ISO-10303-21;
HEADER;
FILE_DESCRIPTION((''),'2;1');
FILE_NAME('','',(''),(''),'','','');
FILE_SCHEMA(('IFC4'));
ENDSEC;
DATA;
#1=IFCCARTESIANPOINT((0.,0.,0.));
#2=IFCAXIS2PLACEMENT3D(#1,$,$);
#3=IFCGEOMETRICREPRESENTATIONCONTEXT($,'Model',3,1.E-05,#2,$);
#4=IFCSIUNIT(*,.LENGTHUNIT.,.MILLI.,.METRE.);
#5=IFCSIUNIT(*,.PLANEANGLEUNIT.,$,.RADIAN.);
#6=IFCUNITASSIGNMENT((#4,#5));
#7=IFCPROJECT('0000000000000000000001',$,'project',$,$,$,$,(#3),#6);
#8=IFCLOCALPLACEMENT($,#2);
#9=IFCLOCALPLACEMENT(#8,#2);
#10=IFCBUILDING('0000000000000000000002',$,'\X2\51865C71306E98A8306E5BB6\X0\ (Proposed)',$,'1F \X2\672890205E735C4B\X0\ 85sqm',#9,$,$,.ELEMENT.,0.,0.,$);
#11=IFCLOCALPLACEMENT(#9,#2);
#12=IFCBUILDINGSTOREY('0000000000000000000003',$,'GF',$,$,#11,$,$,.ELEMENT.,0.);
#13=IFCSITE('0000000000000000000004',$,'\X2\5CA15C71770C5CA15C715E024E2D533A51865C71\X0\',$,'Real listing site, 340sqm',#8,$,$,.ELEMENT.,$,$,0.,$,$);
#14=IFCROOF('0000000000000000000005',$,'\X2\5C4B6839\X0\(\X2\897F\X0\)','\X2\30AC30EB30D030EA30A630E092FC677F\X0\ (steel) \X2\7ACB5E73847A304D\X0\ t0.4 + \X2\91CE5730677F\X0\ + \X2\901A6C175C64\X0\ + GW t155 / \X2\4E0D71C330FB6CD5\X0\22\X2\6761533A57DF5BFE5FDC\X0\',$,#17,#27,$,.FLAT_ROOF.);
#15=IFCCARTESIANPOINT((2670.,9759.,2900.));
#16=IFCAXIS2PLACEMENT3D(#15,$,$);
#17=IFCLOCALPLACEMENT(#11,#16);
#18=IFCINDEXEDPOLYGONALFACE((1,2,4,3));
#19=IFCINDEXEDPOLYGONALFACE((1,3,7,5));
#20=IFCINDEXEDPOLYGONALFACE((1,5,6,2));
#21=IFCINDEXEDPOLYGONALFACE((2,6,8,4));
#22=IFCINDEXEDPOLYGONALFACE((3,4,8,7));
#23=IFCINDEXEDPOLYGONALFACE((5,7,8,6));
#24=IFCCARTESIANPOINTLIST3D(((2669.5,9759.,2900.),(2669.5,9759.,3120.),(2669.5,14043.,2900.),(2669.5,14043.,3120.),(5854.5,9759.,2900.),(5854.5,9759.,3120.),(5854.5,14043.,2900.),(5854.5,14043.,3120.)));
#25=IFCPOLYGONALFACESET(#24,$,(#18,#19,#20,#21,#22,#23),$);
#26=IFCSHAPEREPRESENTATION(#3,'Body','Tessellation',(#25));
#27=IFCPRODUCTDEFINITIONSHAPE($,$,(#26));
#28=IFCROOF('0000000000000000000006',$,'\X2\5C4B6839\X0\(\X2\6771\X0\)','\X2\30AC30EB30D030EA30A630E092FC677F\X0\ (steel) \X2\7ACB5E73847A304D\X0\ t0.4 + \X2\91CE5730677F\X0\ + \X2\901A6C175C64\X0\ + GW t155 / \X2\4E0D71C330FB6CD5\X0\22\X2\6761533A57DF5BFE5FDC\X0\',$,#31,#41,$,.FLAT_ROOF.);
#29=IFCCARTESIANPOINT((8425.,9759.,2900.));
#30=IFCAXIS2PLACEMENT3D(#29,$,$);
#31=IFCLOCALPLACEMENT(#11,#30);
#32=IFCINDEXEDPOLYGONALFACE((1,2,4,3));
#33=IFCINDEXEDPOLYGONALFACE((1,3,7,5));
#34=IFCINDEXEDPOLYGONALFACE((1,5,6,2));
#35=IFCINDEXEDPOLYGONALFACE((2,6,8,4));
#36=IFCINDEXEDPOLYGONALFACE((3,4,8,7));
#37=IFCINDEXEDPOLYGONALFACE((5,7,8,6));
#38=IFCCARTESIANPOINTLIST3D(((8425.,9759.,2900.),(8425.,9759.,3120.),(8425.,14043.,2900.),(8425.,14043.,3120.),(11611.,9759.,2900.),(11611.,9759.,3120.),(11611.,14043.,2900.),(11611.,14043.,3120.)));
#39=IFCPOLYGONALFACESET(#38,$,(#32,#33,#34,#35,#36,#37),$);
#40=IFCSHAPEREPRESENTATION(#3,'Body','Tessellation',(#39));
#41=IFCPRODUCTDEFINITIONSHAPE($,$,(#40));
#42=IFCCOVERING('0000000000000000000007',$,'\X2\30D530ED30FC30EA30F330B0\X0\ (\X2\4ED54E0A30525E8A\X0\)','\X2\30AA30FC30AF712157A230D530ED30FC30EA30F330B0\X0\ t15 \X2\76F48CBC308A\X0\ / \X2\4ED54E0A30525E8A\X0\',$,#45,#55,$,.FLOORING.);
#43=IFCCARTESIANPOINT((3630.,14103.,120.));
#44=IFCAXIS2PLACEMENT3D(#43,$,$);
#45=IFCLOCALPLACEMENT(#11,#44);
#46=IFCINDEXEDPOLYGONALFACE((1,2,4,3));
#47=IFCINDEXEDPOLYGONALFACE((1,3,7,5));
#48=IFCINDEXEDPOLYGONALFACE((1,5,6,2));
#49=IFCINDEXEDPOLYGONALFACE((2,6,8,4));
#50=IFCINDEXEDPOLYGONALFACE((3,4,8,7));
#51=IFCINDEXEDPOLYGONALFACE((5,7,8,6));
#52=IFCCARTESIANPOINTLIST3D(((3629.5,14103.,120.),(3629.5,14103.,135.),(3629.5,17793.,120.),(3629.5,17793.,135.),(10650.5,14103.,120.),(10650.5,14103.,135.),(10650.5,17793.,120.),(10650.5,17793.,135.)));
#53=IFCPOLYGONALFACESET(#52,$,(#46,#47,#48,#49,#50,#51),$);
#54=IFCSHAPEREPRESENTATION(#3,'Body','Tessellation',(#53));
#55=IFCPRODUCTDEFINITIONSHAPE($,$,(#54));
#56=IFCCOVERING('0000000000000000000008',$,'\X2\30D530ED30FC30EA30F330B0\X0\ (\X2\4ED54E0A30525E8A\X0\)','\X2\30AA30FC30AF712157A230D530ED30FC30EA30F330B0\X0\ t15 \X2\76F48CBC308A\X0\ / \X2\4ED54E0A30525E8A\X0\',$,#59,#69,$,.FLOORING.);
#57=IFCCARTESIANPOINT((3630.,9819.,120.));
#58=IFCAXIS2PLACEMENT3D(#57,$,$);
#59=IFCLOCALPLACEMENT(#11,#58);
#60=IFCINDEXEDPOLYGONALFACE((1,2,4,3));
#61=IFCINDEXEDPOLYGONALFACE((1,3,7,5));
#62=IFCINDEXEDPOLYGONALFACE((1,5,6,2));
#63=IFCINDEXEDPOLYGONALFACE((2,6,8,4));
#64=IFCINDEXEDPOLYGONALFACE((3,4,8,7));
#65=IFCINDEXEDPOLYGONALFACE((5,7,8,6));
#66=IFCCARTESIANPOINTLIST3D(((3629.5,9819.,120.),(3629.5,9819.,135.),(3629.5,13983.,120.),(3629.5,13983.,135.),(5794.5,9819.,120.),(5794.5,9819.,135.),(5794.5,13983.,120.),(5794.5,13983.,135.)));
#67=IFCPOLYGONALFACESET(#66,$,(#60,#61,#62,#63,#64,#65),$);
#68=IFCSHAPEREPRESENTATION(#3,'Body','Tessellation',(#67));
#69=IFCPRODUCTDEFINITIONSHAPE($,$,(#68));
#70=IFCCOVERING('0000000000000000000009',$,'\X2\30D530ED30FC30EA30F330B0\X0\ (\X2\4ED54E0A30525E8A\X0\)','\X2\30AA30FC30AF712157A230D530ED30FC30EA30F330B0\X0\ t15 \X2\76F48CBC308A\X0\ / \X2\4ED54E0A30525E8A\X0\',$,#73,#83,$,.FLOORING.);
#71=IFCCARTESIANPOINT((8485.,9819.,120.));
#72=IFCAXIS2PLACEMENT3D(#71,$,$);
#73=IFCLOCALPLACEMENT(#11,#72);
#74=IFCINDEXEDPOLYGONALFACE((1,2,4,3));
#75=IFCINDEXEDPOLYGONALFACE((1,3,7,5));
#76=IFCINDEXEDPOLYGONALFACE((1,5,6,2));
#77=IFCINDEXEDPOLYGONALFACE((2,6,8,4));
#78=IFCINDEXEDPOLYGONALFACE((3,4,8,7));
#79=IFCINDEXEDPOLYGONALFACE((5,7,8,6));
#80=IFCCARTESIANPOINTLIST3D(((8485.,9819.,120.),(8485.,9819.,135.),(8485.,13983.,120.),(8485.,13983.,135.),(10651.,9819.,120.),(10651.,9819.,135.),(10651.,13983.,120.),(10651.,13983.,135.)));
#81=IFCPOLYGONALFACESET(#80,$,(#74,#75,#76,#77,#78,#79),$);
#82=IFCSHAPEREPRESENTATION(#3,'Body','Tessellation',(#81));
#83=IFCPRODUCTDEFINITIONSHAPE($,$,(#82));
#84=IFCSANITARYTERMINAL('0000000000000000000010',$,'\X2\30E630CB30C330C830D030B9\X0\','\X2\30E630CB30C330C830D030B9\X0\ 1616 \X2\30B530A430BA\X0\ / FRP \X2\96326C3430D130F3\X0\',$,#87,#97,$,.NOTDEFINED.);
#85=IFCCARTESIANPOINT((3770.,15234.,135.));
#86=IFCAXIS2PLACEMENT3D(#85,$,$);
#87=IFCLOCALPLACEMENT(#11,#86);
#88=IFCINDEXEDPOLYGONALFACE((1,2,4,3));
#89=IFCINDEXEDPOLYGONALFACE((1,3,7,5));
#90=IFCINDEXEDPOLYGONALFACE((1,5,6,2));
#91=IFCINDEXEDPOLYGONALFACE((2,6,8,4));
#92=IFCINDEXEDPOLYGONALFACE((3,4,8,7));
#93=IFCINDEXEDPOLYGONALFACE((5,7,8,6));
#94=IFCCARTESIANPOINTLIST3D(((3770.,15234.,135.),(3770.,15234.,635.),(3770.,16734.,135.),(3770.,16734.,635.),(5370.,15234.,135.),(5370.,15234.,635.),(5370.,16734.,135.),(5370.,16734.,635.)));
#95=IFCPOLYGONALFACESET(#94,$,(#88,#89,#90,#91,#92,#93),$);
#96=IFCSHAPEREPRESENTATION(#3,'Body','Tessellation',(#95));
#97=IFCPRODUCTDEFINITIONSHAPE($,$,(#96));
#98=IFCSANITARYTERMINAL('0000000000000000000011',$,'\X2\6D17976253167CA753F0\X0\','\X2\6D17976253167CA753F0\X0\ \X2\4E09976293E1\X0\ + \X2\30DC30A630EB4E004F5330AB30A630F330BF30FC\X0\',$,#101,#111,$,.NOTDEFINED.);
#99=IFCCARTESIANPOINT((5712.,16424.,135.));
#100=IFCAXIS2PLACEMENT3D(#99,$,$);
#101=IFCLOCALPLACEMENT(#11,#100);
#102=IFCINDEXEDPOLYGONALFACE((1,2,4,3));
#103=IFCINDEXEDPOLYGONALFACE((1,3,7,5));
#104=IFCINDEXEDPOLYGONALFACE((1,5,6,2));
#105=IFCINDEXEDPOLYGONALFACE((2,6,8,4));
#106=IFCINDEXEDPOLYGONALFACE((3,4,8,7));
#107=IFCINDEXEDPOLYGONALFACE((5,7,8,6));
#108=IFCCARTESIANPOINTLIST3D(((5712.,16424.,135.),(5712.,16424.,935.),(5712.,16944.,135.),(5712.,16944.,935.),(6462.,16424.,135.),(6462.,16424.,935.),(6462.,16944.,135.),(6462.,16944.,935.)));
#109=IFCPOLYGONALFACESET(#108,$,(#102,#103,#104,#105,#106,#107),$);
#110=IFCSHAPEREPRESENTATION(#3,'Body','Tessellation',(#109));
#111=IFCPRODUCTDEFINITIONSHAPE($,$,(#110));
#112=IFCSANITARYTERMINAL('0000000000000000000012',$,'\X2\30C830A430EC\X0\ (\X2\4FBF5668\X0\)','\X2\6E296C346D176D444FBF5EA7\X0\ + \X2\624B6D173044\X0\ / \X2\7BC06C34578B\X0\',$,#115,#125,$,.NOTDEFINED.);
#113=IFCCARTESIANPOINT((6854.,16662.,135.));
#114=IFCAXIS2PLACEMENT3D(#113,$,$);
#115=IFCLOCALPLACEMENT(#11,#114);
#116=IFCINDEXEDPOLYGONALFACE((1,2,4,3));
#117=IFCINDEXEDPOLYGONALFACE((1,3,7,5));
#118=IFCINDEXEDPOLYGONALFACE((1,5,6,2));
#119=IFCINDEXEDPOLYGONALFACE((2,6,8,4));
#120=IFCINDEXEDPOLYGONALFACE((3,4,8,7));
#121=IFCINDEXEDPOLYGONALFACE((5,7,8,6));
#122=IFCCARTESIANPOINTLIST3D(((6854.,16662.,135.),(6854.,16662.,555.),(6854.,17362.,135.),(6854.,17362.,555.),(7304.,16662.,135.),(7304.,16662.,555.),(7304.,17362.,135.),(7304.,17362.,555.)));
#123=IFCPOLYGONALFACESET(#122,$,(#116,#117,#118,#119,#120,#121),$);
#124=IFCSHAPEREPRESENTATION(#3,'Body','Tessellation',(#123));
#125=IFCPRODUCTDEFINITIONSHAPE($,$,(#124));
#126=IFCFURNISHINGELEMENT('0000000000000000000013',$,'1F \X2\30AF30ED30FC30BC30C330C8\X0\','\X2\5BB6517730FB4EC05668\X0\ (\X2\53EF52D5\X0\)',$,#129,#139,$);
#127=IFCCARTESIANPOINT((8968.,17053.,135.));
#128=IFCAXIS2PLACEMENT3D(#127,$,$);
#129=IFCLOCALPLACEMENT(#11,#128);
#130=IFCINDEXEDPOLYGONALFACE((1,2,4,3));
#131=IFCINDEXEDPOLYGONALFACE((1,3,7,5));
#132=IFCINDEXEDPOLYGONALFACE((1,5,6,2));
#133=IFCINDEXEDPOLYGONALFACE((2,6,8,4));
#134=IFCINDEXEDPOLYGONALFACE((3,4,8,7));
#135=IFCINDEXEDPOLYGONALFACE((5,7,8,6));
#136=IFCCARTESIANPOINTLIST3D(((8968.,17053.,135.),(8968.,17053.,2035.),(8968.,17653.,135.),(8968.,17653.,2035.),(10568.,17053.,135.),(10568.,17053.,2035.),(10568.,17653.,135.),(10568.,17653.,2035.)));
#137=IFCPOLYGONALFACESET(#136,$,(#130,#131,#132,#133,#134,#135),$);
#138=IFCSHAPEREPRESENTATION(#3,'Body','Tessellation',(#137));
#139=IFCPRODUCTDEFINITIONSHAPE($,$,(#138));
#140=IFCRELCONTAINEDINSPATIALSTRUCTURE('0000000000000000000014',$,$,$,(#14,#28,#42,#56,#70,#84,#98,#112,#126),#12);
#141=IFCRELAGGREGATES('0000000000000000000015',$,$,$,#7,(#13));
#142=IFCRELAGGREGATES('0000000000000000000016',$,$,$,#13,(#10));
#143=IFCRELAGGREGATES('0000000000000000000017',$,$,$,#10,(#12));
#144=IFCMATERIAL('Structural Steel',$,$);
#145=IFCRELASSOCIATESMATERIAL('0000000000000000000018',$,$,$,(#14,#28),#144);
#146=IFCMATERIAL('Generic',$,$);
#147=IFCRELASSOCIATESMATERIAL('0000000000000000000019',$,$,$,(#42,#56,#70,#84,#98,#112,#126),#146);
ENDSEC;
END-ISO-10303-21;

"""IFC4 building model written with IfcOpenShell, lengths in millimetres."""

from ifc_helpers import new_model, si_unit, frame, frame_2d, origin, place, context, project, spatial, rectangle, extrude, material, element, save


model = new_model("IFC4")

# Units and contexts
model_context = context("Model", 3, precision=1e-05, world=origin())
ifc_project = project(units=[si_unit("LENGTHUNIT", "METRE", prefix="MILLI"), si_unit("PLANEANGLEUNIT", "RADIAN")], contexts=[model_context])

# Site, building, storey
site_placement = place(None, origin())
site = spatial("IfcSite", under=ifc_project, at=site_placement, Name="岡山県岡山市中区円山", ObjectType="Real listing site, 340sqm", CompositionType="ELEMENT", RefElevation=0.0)
building_placement = place(site_placement, origin())
building = spatial("IfcBuilding", under=site, at=building_placement, Name="円山の風の家 (Proposed)", ObjectType="1F 木造平屋 85sqm", CompositionType="ELEMENT", ElevationOfRefHeight=0.0, ElevationOfTerrain=0.0)
storey_placement = place(building_placement, origin())
storey = spatial("IfcBuildingStorey", under=building, at=storey_placement, Name="GF", CompositionType="ELEMENT", Elevation=0.0)

# Roofs
ifc_material_1 = material(Name="Structural Steel")
roof_1_placement = place(storey_placement, frame((2670.0, 9759.0, 2900.0)))
element("IfcRoof", 1, at=roof_1_placement, inside=storey, material=ifc_material_1, Name="屋根(西)", Description="ガルバリウム鋼板 (steel) 立平葺き t0.4 + 野地板 + 通気層 + GW t155 / 不燃・法22条区域対応", PredefinedType="FLAT_ROOF", context=model_context, shape_type="SweptSolid", body=[
    extrude(rectangle(XDim=3185.0, YDim=4284.0, at=frame_2d((1592.0, 2142.0))), frame((2670.0, 9759.0, 2900.0)), (0.0, 0.0, 1.0), 220.0),
])
roof_2_placement = place(storey_placement, frame((8425.0, 9759.0, 2900.0)))
element("IfcRoof", 2, at=roof_2_placement, inside=storey, material=ifc_material_1, Name="屋根(東)", Description="ガルバリウム鋼板 (steel) 立平葺き t0.4 + 野地板 + 通気層 + GW t155 / 不燃・法22条区域対応", PredefinedType="FLAT_ROOF", context=model_context, shape_type="SweptSolid", body=[
    extrude(rectangle(XDim=3186.0, YDim=4284.0, at=frame_2d((1593.0, 2142.0))), frame((8425.0, 9759.0, 2900.0)), (0.0, 0.0, 1.0), 220.0),
])

# Coverings
ifc_material_2 = material(Name="Generic")
covering_1_placement = place(storey_placement, frame((3630.0, 14103.0, 120.0)))
element("IfcCovering", 3, at=covering_1_placement, inside=storey, material=ifc_material_2, Name="フローリング (仕上げ床)", Description="オーク無垢フローリング t15 直貼り / 仕上げ床", PredefinedType="FLOORING", context=model_context, shape_type="SweptSolid", body=[
    extrude(rectangle(XDim=7021.0, YDim=3690.0, at=frame_2d((3510.0, 1845.0))), frame((3630.0, 14103.0, 120.0)), (0.0, 0.0, 1.0), 15.0),
])
covering_2_placement = place(storey_placement, frame((3630.0, 9819.0, 120.0)))
element("IfcCovering", 4, at=covering_2_placement, inside=storey, material=ifc_material_2, Name="フローリング (仕上げ床)", Description="オーク無垢フローリング t15 直貼り / 仕上げ床", PredefinedType="FLOORING", context=model_context, shape_type="SweptSolid", body=[
    extrude(rectangle(XDim=2165.0, YDim=4164.0, at=frame_2d((1082.0, 2082.0))), frame((3630.0, 9819.0, 120.0)), (0.0, 0.0, 1.0), 15.0),
])
covering_3_placement = place(storey_placement, frame((8485.0, 9819.0, 120.0)))
element("IfcCovering", 5, at=covering_3_placement, inside=storey, material=ifc_material_2, Name="フローリング (仕上げ床)", Description="オーク無垢フローリング t15 直貼り / 仕上げ床", PredefinedType="FLOORING", context=model_context, shape_type="SweptSolid", body=[
    extrude(rectangle(XDim=2166.0, YDim=4164.0, at=frame_2d((1083.0, 2082.0))), frame((8485.0, 9819.0, 120.0)), (0.0, 0.0, 1.0), 15.0),
])

# Sanitary terminals
sanitary_terminal_1_placement = place(storey_placement, frame((3770.0, 15234.0, 135.0)))
element("IfcSanitaryTerminal", 6, at=sanitary_terminal_1_placement, inside=storey, material=ifc_material_2, Name="ユニットバス", Description="ユニットバス 1616 サイズ / FRP 防水パン", PredefinedType="NOTDEFINED", context=model_context, shape_type="SweptSolid", body=[
    extrude(rectangle(XDim=1600.0, YDim=1500.0, at=frame_2d((800.0, 750.0))), frame((3770.0, 15234.0, 135.0)), (0.0, 0.0, 1.0), 500.0),
])
sanitary_terminal_2_placement = place(storey_placement, frame((5712.0, 16424.0, 135.0)))
element("IfcSanitaryTerminal", 7, at=sanitary_terminal_2_placement, inside=storey, material=ifc_material_2, Name="洗面化粧台", Description="洗面化粧台 三面鏡 + ボウル一体カウンター", PredefinedType="NOTDEFINED", context=model_context, shape_type="SweptSolid", body=[
    extrude(rectangle(XDim=750.0, YDim=520.0, at=frame_2d((375.0, 260.0))), frame((5712.0, 16424.0, 135.0)), (0.0, 0.0, 1.0), 800.0),
])
sanitary_terminal_3_placement = place(storey_placement, frame((6854.0, 16662.0, 135.0)))
element("IfcSanitaryTerminal", 8, at=sanitary_terminal_3_placement, inside=storey, material=ifc_material_2, Name="トイレ (便器)", Description="温水洗浄便座 + 手洗い / 節水型", PredefinedType="NOTDEFINED", context=model_context, shape_type="SweptSolid", body=[
    extrude(rectangle(XDim=450.0, YDim=700.0, at=frame_2d((225.0, 350.0))), frame((6854.0, 16662.0, 135.0)), (0.0, 0.0, 1.0), 420.0),
])

# Furnishing element
furnishing_placement = place(storey_placement, frame((8968.0, 17053.0, 135.0)))
element("IfcFurnishingElement", 9, at=furnishing_placement, inside=storey, material=ifc_material_2, Name="1F クローゼット", Description="家具・什器 (可動)", context=model_context, shape_type="SweptSolid", body=[
    extrude(rectangle(XDim=1600.0, YDim=600.0, at=frame_2d((800.0, 300.0))), frame((8968.0, 17053.0, 135.0)), (0.0, 0.0, 1.0), 1900.0),
])

save(model, "model.ifc")
